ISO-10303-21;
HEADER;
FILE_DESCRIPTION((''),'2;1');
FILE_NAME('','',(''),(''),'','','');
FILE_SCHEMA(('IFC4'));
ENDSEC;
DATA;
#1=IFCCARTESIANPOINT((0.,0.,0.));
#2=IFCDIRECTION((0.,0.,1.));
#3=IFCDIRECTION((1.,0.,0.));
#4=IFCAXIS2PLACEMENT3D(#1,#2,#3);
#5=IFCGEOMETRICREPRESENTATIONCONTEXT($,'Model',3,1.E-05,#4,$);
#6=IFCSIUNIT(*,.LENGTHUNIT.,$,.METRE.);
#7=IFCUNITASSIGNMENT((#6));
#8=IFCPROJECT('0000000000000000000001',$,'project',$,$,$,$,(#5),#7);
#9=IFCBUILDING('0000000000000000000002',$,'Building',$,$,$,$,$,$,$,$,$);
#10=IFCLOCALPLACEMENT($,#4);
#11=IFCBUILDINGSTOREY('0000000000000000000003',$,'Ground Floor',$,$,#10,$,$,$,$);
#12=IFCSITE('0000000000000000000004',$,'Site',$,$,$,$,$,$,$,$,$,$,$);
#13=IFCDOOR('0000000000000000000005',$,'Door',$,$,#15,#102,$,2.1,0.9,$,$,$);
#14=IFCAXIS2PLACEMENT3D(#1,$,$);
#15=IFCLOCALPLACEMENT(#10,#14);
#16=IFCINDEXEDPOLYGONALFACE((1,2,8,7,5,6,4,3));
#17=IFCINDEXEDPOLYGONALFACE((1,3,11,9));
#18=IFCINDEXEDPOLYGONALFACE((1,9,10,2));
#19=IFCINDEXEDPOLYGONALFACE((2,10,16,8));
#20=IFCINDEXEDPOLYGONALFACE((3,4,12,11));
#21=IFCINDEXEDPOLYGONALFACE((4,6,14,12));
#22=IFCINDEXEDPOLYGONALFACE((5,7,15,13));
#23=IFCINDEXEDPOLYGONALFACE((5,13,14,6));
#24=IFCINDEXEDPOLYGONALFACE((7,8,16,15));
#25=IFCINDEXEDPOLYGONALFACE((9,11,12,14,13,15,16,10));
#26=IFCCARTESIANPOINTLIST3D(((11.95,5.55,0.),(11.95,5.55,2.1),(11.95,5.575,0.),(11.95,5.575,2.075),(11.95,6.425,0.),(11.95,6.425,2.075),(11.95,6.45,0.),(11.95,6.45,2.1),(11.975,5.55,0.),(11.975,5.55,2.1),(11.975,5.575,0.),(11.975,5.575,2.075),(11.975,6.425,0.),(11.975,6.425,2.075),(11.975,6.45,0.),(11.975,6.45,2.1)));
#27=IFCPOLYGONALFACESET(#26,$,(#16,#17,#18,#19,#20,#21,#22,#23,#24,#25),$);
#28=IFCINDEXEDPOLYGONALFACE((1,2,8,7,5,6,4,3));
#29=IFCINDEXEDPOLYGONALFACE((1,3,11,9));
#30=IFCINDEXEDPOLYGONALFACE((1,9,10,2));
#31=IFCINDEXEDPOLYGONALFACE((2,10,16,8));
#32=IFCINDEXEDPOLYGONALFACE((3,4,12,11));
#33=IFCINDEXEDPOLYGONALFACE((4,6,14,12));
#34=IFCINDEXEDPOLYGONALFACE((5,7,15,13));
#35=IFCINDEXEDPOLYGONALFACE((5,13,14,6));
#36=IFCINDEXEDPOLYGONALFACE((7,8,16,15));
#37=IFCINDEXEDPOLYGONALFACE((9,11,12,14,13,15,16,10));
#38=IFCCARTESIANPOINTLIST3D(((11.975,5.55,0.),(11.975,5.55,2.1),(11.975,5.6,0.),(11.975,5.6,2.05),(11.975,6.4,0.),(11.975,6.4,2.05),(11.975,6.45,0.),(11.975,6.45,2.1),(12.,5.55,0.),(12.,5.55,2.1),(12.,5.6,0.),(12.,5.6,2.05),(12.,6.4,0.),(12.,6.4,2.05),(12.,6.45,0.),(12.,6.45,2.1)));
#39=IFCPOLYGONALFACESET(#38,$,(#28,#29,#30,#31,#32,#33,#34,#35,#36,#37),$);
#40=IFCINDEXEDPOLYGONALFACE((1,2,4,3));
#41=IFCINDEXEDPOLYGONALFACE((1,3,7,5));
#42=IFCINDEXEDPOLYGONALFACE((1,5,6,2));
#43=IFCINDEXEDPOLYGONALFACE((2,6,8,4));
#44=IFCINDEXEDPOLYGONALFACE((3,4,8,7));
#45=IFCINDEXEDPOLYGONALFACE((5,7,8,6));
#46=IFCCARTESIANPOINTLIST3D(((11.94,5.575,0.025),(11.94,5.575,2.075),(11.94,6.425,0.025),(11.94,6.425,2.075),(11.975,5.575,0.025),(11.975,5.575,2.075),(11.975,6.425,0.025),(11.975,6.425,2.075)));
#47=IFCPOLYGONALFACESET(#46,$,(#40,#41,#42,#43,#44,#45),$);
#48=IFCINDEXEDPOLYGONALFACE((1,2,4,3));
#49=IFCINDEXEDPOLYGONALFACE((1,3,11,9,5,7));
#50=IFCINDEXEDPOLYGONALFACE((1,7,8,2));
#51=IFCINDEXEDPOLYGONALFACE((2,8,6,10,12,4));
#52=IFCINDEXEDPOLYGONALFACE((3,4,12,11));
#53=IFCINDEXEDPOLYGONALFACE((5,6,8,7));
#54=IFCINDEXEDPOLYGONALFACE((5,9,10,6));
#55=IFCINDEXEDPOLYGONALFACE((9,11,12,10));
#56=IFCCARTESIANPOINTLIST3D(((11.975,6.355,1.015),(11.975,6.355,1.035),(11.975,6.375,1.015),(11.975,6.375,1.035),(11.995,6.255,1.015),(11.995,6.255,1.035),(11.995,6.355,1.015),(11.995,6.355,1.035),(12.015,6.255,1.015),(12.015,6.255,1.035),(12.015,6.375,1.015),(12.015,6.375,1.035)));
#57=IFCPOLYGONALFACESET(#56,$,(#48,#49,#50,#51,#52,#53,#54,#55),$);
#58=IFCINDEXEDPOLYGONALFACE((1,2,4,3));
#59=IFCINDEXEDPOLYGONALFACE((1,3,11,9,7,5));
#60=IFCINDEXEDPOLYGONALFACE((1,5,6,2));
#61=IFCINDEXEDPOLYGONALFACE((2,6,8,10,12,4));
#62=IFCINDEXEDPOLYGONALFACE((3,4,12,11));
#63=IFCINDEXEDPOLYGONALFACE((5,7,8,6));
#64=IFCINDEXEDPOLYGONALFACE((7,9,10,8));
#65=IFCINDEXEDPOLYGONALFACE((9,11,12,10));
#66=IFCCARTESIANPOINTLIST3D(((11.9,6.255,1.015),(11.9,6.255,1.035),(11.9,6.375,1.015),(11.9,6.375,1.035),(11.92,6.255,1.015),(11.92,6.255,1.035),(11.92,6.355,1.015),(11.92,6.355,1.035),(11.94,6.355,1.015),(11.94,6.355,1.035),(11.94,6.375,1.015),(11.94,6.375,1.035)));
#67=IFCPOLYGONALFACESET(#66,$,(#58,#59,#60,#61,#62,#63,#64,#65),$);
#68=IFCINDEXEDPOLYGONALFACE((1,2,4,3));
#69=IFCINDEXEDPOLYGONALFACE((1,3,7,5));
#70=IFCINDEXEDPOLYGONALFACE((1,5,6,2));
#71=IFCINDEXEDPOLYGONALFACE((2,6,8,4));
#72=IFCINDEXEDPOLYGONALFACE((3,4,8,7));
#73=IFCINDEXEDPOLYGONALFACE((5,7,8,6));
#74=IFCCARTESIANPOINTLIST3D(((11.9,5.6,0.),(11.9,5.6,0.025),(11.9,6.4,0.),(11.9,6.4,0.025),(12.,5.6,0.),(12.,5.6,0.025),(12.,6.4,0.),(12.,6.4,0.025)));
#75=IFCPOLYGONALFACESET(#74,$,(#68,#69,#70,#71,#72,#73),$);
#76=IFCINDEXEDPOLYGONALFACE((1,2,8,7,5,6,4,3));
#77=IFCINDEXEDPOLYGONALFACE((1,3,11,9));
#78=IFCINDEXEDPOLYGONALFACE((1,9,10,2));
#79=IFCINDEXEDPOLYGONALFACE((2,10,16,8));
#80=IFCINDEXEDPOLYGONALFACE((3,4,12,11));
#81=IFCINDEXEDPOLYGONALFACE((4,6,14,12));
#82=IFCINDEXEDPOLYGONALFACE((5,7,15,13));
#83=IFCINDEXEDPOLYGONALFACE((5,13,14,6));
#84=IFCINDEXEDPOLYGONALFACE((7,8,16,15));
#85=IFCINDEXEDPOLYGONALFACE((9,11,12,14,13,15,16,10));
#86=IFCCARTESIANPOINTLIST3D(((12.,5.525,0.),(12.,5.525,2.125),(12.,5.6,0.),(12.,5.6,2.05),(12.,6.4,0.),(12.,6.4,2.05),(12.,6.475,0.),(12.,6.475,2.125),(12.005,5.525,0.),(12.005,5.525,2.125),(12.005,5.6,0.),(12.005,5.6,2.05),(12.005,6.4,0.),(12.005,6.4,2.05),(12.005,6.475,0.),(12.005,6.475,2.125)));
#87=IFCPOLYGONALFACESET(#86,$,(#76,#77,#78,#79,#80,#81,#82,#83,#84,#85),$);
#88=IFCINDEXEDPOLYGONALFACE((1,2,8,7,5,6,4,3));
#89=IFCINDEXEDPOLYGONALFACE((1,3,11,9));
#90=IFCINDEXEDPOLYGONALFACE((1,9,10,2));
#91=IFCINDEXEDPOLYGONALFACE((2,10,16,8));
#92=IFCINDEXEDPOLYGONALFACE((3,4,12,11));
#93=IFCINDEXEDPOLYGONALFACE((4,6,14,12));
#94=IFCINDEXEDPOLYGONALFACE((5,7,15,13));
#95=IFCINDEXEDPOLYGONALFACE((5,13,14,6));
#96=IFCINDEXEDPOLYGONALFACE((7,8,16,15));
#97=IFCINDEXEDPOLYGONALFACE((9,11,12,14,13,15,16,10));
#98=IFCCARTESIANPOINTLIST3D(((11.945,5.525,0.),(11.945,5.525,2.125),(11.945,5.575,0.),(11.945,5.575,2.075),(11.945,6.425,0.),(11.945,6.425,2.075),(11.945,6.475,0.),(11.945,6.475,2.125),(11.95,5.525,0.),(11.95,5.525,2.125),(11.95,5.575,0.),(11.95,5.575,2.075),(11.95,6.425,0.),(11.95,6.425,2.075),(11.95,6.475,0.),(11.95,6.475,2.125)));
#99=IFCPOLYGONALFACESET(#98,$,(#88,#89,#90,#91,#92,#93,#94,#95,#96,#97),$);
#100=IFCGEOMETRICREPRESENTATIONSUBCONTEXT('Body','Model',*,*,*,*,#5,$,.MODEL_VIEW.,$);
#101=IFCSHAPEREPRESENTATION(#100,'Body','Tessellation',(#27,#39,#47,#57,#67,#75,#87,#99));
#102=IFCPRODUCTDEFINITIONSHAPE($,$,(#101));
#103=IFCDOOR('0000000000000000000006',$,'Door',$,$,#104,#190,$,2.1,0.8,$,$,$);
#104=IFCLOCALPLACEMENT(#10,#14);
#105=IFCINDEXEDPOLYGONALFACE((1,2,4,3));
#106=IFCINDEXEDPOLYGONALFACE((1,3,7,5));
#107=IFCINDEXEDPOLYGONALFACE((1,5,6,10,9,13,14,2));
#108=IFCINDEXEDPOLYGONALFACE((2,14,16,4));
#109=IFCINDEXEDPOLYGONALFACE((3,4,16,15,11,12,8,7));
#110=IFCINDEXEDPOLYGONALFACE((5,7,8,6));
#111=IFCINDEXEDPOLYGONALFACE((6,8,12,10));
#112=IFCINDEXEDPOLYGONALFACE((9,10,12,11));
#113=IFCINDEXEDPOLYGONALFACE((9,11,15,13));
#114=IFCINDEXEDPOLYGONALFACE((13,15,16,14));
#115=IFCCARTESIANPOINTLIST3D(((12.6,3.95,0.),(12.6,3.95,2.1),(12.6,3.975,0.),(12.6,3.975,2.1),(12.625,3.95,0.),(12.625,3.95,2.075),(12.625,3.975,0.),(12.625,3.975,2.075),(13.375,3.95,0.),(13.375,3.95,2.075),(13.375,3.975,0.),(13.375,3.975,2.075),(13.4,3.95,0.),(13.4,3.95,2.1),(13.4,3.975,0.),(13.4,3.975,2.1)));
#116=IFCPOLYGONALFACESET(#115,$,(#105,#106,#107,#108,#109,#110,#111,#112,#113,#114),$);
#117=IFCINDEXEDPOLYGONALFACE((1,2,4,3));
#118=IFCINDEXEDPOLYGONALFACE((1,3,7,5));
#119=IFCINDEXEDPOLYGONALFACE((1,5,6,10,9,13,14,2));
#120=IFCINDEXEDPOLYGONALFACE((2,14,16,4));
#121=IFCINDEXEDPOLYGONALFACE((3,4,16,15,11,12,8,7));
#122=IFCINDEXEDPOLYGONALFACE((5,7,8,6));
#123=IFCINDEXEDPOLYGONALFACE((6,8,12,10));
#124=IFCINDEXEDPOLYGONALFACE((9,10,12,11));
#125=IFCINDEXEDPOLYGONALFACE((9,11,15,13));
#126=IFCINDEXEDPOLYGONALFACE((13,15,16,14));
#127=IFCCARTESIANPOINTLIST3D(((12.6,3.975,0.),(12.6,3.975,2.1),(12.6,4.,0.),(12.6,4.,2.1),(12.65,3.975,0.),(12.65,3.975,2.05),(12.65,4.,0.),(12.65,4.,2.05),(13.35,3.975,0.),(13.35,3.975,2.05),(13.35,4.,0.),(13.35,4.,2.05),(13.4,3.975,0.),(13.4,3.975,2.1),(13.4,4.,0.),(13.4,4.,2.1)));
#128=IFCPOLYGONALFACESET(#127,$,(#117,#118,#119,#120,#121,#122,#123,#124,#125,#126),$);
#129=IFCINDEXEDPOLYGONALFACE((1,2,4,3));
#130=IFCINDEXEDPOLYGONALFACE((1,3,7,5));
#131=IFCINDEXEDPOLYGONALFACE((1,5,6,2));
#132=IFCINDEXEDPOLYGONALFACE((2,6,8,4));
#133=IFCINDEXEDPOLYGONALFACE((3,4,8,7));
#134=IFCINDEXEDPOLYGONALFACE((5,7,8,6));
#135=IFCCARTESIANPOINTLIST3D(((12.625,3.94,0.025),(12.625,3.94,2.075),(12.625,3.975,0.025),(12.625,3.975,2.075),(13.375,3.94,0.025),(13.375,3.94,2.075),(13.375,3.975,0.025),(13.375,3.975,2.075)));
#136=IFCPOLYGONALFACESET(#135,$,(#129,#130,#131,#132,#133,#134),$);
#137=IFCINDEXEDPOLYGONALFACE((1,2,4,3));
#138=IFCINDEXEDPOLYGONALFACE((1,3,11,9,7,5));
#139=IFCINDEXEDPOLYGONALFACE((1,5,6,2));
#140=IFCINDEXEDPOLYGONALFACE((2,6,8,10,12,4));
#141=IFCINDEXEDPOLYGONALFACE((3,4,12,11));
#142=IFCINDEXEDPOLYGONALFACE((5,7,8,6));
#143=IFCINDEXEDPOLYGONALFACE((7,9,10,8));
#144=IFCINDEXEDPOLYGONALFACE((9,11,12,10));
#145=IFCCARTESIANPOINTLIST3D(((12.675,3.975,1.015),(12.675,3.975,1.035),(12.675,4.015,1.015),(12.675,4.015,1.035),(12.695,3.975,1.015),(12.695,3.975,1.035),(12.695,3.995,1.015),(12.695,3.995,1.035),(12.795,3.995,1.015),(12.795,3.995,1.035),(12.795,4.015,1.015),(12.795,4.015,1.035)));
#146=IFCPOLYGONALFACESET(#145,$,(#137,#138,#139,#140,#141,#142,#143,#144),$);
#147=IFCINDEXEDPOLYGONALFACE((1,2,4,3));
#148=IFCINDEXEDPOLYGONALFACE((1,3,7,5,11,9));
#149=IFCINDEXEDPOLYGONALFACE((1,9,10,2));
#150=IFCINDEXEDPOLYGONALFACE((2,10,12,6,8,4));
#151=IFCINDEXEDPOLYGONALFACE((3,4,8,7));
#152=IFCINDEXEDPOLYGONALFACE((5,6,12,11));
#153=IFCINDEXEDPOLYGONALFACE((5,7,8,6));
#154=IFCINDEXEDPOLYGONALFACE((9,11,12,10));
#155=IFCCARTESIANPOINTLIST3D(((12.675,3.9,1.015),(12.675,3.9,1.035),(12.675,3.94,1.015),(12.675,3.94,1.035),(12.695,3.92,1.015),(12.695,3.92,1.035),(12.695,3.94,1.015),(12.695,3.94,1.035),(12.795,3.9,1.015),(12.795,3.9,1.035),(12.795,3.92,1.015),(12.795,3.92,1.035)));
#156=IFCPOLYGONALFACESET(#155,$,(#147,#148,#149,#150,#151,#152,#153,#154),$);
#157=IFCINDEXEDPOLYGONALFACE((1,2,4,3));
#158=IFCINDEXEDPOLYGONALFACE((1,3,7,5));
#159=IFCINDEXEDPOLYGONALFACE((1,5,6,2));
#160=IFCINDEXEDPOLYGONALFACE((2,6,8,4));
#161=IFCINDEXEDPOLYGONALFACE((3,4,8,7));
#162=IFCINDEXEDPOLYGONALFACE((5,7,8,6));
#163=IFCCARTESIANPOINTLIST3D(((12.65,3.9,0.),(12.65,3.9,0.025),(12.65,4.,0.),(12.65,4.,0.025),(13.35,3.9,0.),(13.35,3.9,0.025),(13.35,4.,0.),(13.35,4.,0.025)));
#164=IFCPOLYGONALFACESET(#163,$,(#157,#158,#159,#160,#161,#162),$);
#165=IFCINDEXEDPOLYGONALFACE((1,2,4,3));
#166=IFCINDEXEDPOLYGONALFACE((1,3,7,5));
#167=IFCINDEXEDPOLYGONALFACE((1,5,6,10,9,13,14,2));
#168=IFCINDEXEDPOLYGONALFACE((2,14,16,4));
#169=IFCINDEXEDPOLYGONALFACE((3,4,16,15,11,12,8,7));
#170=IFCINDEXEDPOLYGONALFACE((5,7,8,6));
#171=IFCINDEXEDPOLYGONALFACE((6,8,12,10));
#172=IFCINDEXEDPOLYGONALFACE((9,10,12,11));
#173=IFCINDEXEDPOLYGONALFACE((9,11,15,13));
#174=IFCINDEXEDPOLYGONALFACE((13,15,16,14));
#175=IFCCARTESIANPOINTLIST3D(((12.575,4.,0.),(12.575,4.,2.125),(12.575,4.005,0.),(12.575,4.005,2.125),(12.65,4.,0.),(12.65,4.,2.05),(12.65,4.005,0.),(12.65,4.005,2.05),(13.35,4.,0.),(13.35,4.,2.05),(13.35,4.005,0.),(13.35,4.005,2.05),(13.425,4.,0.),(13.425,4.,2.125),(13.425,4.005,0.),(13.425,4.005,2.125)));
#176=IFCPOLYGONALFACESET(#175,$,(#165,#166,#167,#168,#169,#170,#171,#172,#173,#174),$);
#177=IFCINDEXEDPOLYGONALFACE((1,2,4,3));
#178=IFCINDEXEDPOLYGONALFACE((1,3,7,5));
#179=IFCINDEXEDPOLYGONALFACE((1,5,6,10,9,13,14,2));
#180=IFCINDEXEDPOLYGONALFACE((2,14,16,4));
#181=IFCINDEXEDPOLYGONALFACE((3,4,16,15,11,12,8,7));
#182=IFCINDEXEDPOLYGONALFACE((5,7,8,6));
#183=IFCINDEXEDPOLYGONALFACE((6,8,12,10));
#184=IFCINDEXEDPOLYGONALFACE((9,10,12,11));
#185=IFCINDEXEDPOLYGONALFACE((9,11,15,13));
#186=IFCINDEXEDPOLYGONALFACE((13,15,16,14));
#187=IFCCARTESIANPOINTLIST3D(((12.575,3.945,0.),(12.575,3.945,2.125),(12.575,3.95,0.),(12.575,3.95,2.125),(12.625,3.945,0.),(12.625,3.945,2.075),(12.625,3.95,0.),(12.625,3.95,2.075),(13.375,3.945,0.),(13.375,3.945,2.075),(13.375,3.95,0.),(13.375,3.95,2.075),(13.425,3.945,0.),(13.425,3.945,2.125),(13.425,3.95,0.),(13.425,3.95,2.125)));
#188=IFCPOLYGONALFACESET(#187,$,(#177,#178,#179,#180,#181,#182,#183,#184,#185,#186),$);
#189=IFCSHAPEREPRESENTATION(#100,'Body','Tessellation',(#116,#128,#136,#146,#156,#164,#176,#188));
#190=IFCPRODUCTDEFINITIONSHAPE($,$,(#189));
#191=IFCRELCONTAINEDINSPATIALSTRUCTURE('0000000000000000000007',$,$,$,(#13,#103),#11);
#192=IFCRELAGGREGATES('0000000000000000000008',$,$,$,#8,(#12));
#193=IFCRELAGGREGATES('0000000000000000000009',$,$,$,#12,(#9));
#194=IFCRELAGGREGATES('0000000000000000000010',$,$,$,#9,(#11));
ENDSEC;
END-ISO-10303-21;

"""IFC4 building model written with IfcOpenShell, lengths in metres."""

from ifc_helpers import new_model, si_unit, frame, origin_with_axes, place, context, subcontext, project, spatial, line, indexed_curve, outline, extrude, element, save


model = new_model("IFC4")

# Units and contexts
model_context = context("Model", 3, precision=1e-05, world=origin_with_axes())
body_context = subcontext(model_context, "Body", "Model", "MODEL_VIEW")
ifc_project = project(units=[si_unit("LENGTHUNIT", "METRE")], contexts=[model_context])

# Site, building, storey
site = spatial("IfcSite", under=ifc_project, Name="Site")
building = spatial("IfcBuilding", under=site, Name="Building")
storey_placement = place(None, origin_with_axes())
storey = spatial("IfcBuildingStorey", under=building, at=storey_placement, Name="Ground Floor")

# Doors
door_1_placement = place(storey_placement, frame((12.0, 5.55, 0.0), z_axis=(0.0, 0.0, 1.0), x_axis=(0.0, 1.0, 0.0)))
element("IfcDoor", 1, at=door_1_placement, inside=storey, Name="Door", OverallHeight=2.1, OverallWidth=0.9, context=body_context, shape_type="SweptSolid", body=[
    extrude(outline(indexed_curve([(0.0, 0.0), (0.0, 2.1), (0.9, 2.1), (0.9, 0.0), (0.875, 0.0), (0.875, 2.075), (0.025, 2.075), (0.025, 0.0)], segments=[line(1, 2, 3, 4, 5, 6, 7, 8, 1)])), frame((0.0, 0.025, 0.0), z_axis=(0.0, -1.0, 0.0), x_axis=(1.0, 0.0, 0.0)), (0.0, 0.0, -1.0), 0.025),
    extrude(outline(indexed_curve([(0.0, 0.0), (0.0, 2.1), (0.9, 2.1), (0.9, 0.0), (0.85, 0.0), (0.85, 2.05), (0.05, 2.05), (0.05, 0.0)], segments=[line(1, 2, 3, 4, 5, 6, 7, 8, 1)])), frame((0.0, 0.0, 0.0), z_axis=(0.0, -1.0, 0.0), x_axis=(1.0, 0.0, 0.0)), (0.0, 0.0, -1.0), 0.025),
    extrude(outline(indexed_curve([(0.0, 0.0), (0.85, 0.0), (0.85, 0.035), (0.0, 0.035)], segments=[line(1, 2, 3, 4, 1)])), frame((0.025, 0.025, 0.025), z_axis=(0.0, 0.0, 1.0), x_axis=(1.0, 0.0, 0.0)), (0.0, 0.0, 1.0), 2.05),
    extrude(outline(indexed_curve([(0.0, 0.0), (0.0, -0.04), (-0.12, -0.04), (-0.12, -0.02), (-0.02, -0.02), (-0.02, 0.0)], segments=[line(1, 2, 3, 4, 5, 6, 1)])), frame((0.825, 0.025, 1.015), z_axis=(0.0, 0.0, 1.0), x_axis=(1.0, 0.0, 0.0)), (0.0, 0.0, 1.0), 0.02),
    extrude(outline(indexed_curve([(0.0, 0.0), (0.0, 0.04), (-0.12, 0.04), (-0.12, 0.02), (-0.02, 0.02), (-0.02, 0.0)], segments=[line(1, 2, 3, 4, 5, 6, 1)])), frame((0.825, 0.06, 1.015), z_axis=(0.0, 0.0, 1.0), x_axis=(1.0, 0.0, 0.0)), (0.0, 0.0, 1.0), 0.02),
    extrude(outline(indexed_curve([(0.0, 0.0), (0.8, 0.0), (0.8, 0.1), (0.0, 0.1)], segments=[line(1, 2, 3, 4, 1)])), frame((0.05, 0.0, 0.0), z_axis=(0.0, 0.0, 1.0), x_axis=(1.0, 0.0, 0.0)), (0.0, 0.0, 1.0), 0.025),
    extrude(outline(indexed_curve([(0.0, 0.0), (0.0, 2.125), (0.95, 2.125), (0.95, 0.0), (0.875, 0.0), (0.875, 2.05), (0.075, 2.05), (0.075, 0.0)], segments=[line(1, 2, 3, 4, 5, 6, 7, 8, 1)])), frame((-0.025, -0.005, 0.0), z_axis=(0.0, -1.0, 0.0), x_axis=(1.0, 0.0, 0.0)), (0.0, 0.0, -1.0), 0.005),
    extrude(outline(indexed_curve([(0.0, 0.0), (0.0, 2.125), (0.95, 2.125), (0.95, 0.0), (0.9, 0.0), (0.9, 2.075), (0.05, 2.075), (0.05, 0.0)], segments=[line(1, 2, 3, 4, 5, 6, 7, 8, 1)])), frame((-0.025, 0.05, 0.0), z_axis=(0.0, -1.0, 0.0), x_axis=(1.0, 0.0, 0.0)), (0.0, 0.0, -1.0), 0.005),
])
door_2_placement = place(storey_placement, frame((13.4, 4.0, 0.0), z_axis=(0.0, 0.0, 1.0), x_axis=(-1.0, 0.0, 0.0)))
element("IfcDoor", 2, at=door_2_placement, inside=storey, Name="Door", OverallHeight=2.1, OverallWidth=0.8, context=body_context, shape_type="SweptSolid", body=[
    extrude(outline(indexed_curve([(0.0, 0.0), (0.0, 2.1), (0.8, 2.1), (0.8, 0.0), (0.775, 0.0), (0.775, 2.075), (0.025, 2.075), (0.025, 0.0)], segments=[line(1, 2, 3, 4, 5, 6, 7, 8, 1)])), frame((0.0, 0.025, 0.0), z_axis=(0.0, -1.0, 0.0), x_axis=(1.0, 0.0, 0.0)), (0.0, 0.0, -1.0), 0.025),
    extrude(outline(indexed_curve([(0.0, 0.0), (0.0, 2.1), (0.8, 2.1), (0.8, 0.0), (0.75, 0.0), (0.75, 2.05), (0.05, 2.05), (0.05, 0.0)], segments=[line(1, 2, 3, 4, 5, 6, 7, 8, 1)])), frame((0.0, 0.0, 0.0), z_axis=(0.0, -1.0, 0.0), x_axis=(1.0, 0.0, 0.0)), (0.0, 0.0, -1.0), 0.025),
    extrude(outline(indexed_curve([(0.0, 0.0), (0.75, 0.0), (0.75, 0.035), (0.0, 0.035)], segments=[line(1, 2, 3, 4, 1)])), frame((0.025, 0.025, 0.025), z_axis=(0.0, 0.0, 1.0), x_axis=(1.0, 0.0, 0.0)), (0.0, 0.0, 1.0), 2.05),
    extrude(outline(indexed_curve([(0.0, 0.0), (0.0, -0.04), (-0.12, -0.04), (-0.12, -0.02), (-0.02, -0.02), (-0.02, 0.0)], segments=[line(1, 2, 3, 4, 5, 6, 1)])), frame((0.725, 0.025, 1.015), z_axis=(0.0, 0.0, 1.0), x_axis=(1.0, 0.0, 0.0)), (0.0, 0.0, 1.0), 0.02),
    extrude(outline(indexed_curve([(0.0, 0.0), (0.0, 0.04), (-0.12, 0.04), (-0.12, 0.02), (-0.02, 0.02), (-0.02, 0.0)], segments=[line(1, 2, 3, 4, 5, 6, 1)])), frame((0.725, 0.06, 1.015), z_axis=(0.0, 0.0, 1.0), x_axis=(1.0, 0.0, 0.0)), (0.0, 0.0, 1.0), 0.02),
    extrude(outline(indexed_curve([(0.0, 0.0), (0.7, 0.0), (0.7, 0.1), (0.0, 0.1)], segments=[line(1, 2, 3, 4, 1)])), frame((0.05, 0.0, 0.0), z_axis=(0.0, 0.0, 1.0), x_axis=(1.0, 0.0, 0.0)), (0.0, 0.0, 1.0), 0.025),
    extrude(outline(indexed_curve([(0.0, 0.0), (0.0, 2.125), (0.85, 2.125), (0.85, 0.0), (0.775, 0.0), (0.775, 2.05), (0.075, 2.05), (0.075, 0.0)], segments=[line(1, 2, 3, 4, 5, 6, 7, 8, 1)])), frame((-0.025, -0.005, 0.0), z_axis=(0.0, -1.0, 0.0), x_axis=(1.0, 0.0, 0.0)), (0.0, 0.0, -1.0), 0.005),
    extrude(outline(indexed_curve([(0.0, 0.0), (0.0, 2.125), (0.85, 2.125), (0.85, 0.0), (0.8, 0.0), (0.8, 2.075), (0.05, 2.075), (0.05, 0.0)], segments=[line(1, 2, 3, 4, 5, 6, 7, 8, 1)])), frame((-0.025, 0.05, 0.0), z_axis=(0.0, -1.0, 0.0), x_axis=(1.0, 0.0, 0.0)), (0.0, 0.0, -1.0), 0.005),
])

save(model, "model.ifc")
